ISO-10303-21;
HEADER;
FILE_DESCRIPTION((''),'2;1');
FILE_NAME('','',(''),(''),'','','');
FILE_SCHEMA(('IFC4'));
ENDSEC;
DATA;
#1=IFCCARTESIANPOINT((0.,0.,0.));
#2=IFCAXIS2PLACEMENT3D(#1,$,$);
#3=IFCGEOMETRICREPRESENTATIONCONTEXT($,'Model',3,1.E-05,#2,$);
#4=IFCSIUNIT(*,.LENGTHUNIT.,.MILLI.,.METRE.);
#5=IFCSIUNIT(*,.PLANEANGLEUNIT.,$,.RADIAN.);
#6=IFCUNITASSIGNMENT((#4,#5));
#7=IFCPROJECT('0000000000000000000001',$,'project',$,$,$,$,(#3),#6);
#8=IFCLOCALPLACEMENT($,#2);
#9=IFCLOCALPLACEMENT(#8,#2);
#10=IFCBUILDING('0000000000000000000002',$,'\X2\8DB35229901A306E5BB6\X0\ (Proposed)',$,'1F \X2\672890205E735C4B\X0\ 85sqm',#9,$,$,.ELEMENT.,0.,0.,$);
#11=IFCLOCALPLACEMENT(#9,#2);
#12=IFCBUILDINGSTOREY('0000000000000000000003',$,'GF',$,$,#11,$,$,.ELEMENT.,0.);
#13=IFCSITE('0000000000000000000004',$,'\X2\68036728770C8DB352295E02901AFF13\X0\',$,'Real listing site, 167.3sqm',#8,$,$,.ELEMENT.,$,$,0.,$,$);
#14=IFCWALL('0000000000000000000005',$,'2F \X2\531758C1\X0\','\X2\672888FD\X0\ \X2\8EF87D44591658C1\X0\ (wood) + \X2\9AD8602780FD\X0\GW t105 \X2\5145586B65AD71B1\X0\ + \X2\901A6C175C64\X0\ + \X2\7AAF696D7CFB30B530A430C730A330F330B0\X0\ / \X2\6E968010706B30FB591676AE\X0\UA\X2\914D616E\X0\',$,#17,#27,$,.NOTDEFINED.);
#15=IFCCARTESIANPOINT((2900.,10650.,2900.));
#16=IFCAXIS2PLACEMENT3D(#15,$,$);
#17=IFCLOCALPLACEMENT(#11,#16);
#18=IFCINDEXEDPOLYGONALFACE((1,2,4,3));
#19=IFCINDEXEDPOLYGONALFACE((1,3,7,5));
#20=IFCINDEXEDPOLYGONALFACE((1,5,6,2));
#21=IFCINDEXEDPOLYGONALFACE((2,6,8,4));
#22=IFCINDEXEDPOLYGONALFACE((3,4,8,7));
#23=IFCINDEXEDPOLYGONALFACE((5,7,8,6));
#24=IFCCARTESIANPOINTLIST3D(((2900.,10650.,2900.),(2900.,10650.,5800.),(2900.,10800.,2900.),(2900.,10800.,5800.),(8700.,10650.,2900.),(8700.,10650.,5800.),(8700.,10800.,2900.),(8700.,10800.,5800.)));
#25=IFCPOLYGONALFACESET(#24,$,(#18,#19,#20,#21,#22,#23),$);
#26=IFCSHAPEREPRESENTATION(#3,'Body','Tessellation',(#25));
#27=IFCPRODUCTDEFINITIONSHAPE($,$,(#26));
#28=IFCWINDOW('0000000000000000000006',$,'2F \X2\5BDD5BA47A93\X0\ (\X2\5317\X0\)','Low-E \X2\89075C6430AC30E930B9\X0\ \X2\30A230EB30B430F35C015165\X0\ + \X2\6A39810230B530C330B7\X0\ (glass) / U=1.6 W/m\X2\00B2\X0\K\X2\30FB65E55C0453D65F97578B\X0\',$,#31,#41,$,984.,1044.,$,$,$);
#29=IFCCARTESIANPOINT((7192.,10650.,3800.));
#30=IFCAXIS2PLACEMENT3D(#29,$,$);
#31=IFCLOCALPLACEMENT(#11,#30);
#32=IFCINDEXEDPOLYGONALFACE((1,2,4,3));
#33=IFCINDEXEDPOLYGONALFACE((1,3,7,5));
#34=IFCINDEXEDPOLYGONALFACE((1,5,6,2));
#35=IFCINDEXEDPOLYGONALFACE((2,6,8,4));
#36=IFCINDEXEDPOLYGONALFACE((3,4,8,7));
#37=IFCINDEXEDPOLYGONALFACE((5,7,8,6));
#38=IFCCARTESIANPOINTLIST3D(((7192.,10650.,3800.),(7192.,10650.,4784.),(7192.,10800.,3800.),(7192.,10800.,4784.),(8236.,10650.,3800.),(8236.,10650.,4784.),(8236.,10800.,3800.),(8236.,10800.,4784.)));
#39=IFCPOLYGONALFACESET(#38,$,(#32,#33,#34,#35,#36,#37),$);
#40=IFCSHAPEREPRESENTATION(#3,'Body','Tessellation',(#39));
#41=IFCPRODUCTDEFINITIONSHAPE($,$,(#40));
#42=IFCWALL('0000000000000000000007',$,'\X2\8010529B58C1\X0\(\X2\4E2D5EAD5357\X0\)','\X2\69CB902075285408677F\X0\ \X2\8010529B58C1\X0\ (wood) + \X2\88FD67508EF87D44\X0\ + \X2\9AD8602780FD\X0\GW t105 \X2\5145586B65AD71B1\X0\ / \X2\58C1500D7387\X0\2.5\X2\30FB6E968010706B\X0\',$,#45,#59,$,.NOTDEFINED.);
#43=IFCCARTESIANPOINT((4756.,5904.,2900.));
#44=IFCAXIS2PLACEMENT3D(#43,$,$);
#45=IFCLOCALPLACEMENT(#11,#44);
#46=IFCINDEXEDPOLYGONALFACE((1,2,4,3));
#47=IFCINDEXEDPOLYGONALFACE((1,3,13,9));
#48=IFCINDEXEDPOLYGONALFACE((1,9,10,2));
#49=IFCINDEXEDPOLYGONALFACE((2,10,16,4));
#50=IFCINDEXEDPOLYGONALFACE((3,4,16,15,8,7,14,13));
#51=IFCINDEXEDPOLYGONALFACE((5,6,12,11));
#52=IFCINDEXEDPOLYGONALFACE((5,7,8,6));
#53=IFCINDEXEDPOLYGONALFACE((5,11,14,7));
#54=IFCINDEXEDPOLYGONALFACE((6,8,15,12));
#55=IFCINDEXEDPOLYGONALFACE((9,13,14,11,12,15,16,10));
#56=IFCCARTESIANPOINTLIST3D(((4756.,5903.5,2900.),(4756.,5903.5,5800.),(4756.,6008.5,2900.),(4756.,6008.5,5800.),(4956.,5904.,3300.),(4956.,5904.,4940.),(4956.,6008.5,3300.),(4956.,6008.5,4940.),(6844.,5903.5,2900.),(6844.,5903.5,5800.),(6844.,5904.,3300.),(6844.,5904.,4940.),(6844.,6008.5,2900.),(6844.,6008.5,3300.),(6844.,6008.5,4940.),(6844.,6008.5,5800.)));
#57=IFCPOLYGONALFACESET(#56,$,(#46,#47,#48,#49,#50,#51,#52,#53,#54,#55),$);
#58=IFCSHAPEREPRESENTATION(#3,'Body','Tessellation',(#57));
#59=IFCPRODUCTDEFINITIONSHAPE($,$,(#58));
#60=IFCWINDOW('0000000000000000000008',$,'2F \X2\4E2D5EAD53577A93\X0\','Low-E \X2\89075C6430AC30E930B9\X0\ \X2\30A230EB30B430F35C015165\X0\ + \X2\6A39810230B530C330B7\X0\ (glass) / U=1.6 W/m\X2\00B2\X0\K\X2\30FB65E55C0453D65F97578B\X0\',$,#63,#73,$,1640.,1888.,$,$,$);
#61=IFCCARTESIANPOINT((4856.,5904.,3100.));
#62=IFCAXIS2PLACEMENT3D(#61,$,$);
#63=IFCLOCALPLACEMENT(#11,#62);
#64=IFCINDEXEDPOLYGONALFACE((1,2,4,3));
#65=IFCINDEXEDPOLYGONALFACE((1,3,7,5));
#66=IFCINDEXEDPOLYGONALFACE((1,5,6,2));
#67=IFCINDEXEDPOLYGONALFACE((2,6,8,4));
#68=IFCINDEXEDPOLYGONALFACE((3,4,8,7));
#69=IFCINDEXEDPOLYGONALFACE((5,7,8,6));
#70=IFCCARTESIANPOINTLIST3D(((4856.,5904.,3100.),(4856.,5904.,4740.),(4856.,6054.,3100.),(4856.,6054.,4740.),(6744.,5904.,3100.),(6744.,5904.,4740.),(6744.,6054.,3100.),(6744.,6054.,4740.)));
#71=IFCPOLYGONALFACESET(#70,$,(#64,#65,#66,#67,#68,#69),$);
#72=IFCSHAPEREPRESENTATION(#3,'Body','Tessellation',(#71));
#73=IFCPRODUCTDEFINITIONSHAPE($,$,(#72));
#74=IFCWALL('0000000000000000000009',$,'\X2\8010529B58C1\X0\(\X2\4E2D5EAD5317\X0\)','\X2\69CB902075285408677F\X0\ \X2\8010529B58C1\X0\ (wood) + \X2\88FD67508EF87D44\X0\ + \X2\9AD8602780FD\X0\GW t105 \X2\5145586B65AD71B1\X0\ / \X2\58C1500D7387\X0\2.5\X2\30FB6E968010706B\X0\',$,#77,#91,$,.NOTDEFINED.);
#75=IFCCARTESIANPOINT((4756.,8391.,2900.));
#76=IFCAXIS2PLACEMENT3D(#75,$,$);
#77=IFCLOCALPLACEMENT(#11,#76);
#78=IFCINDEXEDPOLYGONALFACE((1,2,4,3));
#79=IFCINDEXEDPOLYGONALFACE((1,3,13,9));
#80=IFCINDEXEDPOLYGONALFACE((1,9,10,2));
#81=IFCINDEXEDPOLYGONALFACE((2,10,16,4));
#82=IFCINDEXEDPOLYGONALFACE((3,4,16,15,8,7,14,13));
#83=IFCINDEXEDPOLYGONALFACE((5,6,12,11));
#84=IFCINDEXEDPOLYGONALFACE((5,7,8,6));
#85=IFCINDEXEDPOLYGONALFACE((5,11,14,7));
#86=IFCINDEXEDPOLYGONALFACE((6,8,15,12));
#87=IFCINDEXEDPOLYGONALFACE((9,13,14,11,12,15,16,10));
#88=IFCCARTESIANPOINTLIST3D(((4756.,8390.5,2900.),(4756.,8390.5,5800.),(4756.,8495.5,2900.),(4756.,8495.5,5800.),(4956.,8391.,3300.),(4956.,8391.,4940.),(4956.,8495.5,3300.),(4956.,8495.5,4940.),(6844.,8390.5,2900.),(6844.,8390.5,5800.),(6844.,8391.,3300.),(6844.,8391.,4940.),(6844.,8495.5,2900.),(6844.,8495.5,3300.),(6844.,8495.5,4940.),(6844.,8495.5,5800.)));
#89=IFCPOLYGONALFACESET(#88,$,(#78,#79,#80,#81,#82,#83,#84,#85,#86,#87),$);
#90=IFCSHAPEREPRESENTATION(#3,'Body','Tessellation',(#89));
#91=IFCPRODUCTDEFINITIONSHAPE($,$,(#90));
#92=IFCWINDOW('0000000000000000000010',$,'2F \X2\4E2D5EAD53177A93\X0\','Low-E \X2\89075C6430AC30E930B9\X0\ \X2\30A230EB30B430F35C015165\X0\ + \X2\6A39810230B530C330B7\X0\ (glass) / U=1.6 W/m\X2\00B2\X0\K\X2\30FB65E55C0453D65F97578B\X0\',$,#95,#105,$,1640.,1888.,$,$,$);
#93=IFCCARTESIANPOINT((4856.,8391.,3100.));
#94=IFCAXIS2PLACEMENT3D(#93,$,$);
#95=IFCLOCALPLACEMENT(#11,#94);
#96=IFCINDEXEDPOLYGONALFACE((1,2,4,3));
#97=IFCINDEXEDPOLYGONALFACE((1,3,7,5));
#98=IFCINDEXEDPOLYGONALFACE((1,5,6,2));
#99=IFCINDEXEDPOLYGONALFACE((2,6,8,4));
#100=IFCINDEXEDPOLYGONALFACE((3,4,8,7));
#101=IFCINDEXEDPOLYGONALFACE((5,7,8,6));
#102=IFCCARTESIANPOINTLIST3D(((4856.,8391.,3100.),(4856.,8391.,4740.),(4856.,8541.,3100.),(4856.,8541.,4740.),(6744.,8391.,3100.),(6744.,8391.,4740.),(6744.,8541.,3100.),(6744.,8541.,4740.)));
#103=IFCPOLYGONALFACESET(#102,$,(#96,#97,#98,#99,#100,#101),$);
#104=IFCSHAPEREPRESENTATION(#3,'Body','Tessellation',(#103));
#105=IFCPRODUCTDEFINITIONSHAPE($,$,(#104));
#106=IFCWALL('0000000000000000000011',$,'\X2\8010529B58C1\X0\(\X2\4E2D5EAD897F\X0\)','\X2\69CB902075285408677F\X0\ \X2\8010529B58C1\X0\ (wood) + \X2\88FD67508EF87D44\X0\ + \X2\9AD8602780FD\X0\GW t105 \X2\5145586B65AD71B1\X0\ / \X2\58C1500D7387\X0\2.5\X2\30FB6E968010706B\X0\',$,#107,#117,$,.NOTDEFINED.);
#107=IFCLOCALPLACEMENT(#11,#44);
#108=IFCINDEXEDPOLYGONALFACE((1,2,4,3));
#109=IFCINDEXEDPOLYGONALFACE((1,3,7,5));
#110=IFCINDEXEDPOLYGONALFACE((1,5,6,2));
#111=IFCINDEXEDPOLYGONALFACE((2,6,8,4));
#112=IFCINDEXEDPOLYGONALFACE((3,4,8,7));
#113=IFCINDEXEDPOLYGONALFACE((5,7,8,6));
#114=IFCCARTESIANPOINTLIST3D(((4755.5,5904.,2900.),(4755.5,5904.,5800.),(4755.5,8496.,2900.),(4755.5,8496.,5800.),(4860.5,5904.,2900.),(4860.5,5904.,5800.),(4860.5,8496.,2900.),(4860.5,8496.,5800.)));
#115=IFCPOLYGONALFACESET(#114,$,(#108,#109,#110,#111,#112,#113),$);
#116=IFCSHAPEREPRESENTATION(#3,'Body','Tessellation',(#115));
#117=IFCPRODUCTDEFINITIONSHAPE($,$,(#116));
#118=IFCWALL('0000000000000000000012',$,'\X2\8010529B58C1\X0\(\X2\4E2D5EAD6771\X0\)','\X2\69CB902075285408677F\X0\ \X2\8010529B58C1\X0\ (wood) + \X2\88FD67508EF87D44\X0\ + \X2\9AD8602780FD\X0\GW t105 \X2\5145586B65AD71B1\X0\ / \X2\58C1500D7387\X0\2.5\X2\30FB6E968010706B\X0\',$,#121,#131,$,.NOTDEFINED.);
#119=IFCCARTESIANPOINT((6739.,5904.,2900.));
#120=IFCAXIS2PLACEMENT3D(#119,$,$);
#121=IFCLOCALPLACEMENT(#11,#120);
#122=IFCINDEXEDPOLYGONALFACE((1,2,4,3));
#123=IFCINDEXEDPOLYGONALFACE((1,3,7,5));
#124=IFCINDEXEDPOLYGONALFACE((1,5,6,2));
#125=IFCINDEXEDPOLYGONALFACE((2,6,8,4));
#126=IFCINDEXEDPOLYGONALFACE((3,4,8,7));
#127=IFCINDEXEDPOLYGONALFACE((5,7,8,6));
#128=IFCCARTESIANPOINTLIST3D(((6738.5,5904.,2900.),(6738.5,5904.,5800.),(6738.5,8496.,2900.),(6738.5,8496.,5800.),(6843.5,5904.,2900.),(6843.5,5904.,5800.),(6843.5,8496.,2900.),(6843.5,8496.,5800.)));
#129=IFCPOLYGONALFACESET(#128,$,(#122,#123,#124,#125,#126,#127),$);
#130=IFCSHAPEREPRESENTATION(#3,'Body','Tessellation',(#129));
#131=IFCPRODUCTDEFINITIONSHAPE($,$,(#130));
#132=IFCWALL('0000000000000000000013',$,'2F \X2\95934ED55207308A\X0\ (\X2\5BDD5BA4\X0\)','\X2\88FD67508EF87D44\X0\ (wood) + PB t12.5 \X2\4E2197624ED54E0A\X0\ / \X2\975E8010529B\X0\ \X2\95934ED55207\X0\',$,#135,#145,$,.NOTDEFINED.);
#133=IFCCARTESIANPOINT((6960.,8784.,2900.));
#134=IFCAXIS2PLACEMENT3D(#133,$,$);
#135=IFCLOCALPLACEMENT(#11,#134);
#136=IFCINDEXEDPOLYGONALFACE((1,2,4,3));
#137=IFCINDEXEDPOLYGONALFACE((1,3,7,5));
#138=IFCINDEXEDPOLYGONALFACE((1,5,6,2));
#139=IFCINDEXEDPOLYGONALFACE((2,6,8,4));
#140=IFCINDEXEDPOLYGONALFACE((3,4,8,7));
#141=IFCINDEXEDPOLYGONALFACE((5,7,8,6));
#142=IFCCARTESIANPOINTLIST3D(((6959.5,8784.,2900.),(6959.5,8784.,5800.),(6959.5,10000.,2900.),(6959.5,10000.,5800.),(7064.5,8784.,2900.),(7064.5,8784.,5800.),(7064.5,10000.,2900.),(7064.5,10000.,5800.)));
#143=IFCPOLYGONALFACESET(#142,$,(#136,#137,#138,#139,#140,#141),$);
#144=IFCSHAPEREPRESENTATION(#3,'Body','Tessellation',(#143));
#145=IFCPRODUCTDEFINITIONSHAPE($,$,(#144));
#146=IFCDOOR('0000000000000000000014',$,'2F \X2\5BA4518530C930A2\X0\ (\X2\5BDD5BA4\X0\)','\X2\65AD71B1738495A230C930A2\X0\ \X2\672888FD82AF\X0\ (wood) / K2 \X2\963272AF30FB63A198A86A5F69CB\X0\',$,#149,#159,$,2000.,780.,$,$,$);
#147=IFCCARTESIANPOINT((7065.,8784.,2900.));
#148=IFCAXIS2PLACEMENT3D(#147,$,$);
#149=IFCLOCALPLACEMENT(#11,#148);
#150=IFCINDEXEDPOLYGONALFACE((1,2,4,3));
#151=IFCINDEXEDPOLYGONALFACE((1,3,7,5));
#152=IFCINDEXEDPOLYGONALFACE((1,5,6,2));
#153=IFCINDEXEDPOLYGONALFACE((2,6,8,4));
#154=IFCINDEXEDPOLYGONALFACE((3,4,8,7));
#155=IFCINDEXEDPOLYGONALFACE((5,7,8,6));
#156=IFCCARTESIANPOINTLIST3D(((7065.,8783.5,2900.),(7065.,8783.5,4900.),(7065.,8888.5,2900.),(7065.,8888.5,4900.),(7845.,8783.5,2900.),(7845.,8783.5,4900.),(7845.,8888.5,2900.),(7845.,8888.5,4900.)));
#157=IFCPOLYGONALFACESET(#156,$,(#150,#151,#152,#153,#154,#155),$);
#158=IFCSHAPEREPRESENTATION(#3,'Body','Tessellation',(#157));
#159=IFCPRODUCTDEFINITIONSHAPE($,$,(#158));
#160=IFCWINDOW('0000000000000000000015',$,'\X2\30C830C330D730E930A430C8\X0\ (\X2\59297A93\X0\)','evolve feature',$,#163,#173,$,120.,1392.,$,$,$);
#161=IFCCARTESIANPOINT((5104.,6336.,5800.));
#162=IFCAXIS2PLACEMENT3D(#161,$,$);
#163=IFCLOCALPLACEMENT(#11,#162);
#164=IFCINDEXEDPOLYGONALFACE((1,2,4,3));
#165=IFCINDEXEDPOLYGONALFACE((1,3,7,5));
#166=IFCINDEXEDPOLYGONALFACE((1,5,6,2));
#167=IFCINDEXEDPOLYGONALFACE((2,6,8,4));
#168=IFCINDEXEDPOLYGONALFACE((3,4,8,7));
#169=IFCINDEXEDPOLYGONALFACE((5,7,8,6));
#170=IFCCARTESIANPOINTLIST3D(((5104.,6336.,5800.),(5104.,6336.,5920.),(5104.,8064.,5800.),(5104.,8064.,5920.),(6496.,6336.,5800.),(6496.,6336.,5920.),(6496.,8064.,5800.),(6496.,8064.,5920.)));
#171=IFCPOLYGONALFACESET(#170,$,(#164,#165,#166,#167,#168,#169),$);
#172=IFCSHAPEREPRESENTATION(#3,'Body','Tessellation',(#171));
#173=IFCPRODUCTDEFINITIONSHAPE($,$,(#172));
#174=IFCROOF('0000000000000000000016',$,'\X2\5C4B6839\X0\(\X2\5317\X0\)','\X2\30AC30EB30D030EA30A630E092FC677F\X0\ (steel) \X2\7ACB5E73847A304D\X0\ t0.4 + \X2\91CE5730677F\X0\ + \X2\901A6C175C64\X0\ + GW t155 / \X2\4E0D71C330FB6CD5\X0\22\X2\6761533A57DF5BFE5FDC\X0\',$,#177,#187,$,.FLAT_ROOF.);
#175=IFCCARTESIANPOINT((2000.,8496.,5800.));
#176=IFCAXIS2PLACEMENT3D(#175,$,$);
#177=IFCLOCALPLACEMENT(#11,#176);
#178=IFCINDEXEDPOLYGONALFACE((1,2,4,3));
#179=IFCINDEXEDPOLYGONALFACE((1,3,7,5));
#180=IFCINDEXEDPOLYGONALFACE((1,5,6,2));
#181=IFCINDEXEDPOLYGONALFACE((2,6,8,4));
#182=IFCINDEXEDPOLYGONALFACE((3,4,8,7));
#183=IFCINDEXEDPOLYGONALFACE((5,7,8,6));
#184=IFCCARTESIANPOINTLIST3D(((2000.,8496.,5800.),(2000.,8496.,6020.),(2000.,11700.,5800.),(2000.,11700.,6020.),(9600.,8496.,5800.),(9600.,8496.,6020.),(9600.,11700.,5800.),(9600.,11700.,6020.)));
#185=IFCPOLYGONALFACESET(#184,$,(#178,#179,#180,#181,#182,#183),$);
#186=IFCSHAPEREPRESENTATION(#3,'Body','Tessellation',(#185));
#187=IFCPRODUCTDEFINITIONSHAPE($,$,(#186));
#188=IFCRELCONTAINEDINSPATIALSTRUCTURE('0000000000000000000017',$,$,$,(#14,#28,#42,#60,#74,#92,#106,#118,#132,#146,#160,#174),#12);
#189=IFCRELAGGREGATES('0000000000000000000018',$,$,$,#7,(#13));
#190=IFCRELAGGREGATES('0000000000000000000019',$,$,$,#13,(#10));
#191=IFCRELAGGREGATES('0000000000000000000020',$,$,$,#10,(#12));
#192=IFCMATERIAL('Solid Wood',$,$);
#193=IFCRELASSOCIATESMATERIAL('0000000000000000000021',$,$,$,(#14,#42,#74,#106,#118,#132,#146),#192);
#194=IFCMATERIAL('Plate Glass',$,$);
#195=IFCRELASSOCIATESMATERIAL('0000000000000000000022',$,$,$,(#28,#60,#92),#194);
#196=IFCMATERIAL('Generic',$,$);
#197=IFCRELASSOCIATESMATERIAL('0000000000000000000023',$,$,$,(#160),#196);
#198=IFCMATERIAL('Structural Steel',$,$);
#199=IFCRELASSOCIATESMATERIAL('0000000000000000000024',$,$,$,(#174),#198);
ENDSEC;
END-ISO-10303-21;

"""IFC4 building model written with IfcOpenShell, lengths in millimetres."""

from ifc_helpers import new_model, si_unit, frame, frame_2d, origin, place, context, project, spatial, rectangle, extrude, material, element, fill, save


model = new_model("IFC4")

# Units and contexts
model_context = context("Model", 3, precision=1e-05, world=origin())
ifc_project = project(units=[si_unit("LENGTHUNIT", "METRE", prefix="MILLI"), si_unit("PLANEANGLEUNIT", "RADIAN")], contexts=[model_context])

# Site, building, storey
site_placement = place(None, origin())
site = spatial("IfcSite", under=ifc_project, at=site_placement, Name="栃木県足利市通３", ObjectType="Real listing site, 167.3sqm", CompositionType="ELEMENT", RefElevation=0.0)
building_placement = place(site_placement, origin())
building = spatial("IfcBuilding", under=site, at=building_placement, Name="足利通の家 (Proposed)", ObjectType="1F 木造平屋 85sqm", CompositionType="ELEMENT", ElevationOfRefHeight=0.0, ElevationOfTerrain=0.0)
storey_placement = place(building_placement, origin())
storey = spatial("IfcBuildingStorey", under=building, at=storey_placement, Name="GF", CompositionType="ELEMENT", Elevation=0.0)

# Shared definitions
ifc_material_1 = material(Name="Solid Wood")

# Walls, openings, windows
wall_1_placement = place(storey_placement, frame((2900.0, 10650.0, 2900.0)))
wall_1 = element("IfcWall", 1, at=wall_1_placement, inside=storey, material=ifc_material_1, Name="2F 北壁", Description="木製 軸組外壁 (wood) + 高性能GW t105 充填断熱 + 通気層 + 窯業系サイディング / 準耐火・外皮UA配慮", PredefinedType="NOTDEFINED", context=model_context, shape_type="SweptSolid", body=[
    extrude(rectangle(XDim=5800.0, YDim=150.0, at=frame_2d((2900.0, 75.0))), frame((2900.0, 10650.0, 2900.0)), (0.0, 0.0, 1.0), 2900.0),
])
opening_1_placement = place(storey_placement, frame((7192.0, 10650.0, 3800.0)))
opening_1 = element("IfcOpeningElement", 2, at=opening_1_placement, cuts=wall_1, PredefinedType="NOTDEFINED", context=model_context, shape_type="SweptSolid", body=[
    extrude(rectangle(XDim=1044.0, YDim=150.0, at=frame_2d((522.0, 75.0))), frame((7192.0, 10650.0, 3800.0)), (0.0, 0.0, 1.0), 984.0),
])
ifc_material_2 = material(Name="Plate Glass")
window_1_placement = place(storey_placement, frame((7192.0, 10650.0, 3800.0)))
window_1 = element("IfcWindow", 3, at=window_1_placement, inside=storey, material=ifc_material_2, Name="2F 寝室窓 (北)", Description="Low-E 複層ガラス アルゴン封入 + 樹脂サッシ (glass) / U=1.6 W/m²K・日射取得型", OverallHeight=984.0, OverallWidth=1044.0, context=model_context, shape_type="SweptSolid", body=[
    extrude(rectangle(XDim=1044.0, YDim=150.0, at=frame_2d((522.0, 75.0))), frame((7192.0, 10650.0, 3800.0)), (0.0, 0.0, 1.0), 984.0),
])
fill(opening_1, window_1)
wall_2_placement = place(storey_placement, frame((4756.0, 5904.0, 2900.0)))
wall_2 = element("IfcWall", 4, at=wall_2_placement, inside=storey, material=ifc_material_1, Name="耐力壁(中庭南)", Description="構造用合板 耐力壁 (wood) + 製材軸組 + 高性能GW t105 充填断熱 / 壁倍率2.5・準耐火", PredefinedType="NOTDEFINED", context=model_context, shape_type="SweptSolid", body=[
    extrude(rectangle(XDim=2088.0, YDim=105.0, at=frame_2d((1044.0, 52.0))), frame((4756.0, 5904.0, 2900.0)), (0.0, 0.0, 1.0), 2900.0),
])
opening_2_placement = place(storey_placement, frame((4856.0, 5904.0, 3100.0)))
opening_2 = element("IfcOpeningElement", 5, at=opening_2_placement, cuts=wall_2, PredefinedType="NOTDEFINED", context=model_context, shape_type="SweptSolid", body=[
    extrude(rectangle(XDim=1888.0, YDim=150.0, at=frame_2d((944.0, 75.0))), frame((4856.0, 5904.0, 3100.0)), (0.0, 0.0, 1.0), 1640.0),
])
window_2_placement = place(storey_placement, frame((4856.0, 5904.0, 3100.0)))
window_2 = element("IfcWindow", 6, at=window_2_placement, inside=storey, material=ifc_material_2, Name="2F 中庭南窓", Description="Low-E 複層ガラス アルゴン封入 + 樹脂サッシ (glass) / U=1.6 W/m²K・日射取得型", OverallHeight=1640.0, OverallWidth=1888.0, context=model_context, shape_type="SweptSolid", body=[
    extrude(rectangle(XDim=1888.0, YDim=150.0, at=frame_2d((944.0, 75.0))), frame((4856.0, 5904.0, 3100.0)), (0.0, 0.0, 1.0), 1640.0),
])
fill(opening_2, window_2)
wall_3_placement = place(storey_placement, frame((4756.0, 8391.0, 2900.0)))
wall_3 = element("IfcWall", 7, at=wall_3_placement, inside=storey, material=ifc_material_1, Name="耐力壁(中庭北)", Description="構造用合板 耐力壁 (wood) + 製材軸組 + 高性能GW t105 充填断熱 / 壁倍率2.5・準耐火", PredefinedType="NOTDEFINED", context=model_context, shape_type="SweptSolid", body=[
    extrude(rectangle(XDim=2088.0, YDim=105.0, at=frame_2d((1044.0, 52.0))), frame((4756.0, 8391.0, 2900.0)), (0.0, 0.0, 1.0), 2900.0),
])
opening_3_placement = place(storey_placement, frame((4856.0, 8391.0, 3100.0)))
opening_3 = element("IfcOpeningElement", 8, at=opening_3_placement, cuts=wall_3, PredefinedType="NOTDEFINED", context=model_context, shape_type="SweptSolid", body=[
    extrude(rectangle(XDim=1888.0, YDim=150.0, at=frame_2d((944.0, 75.0))), frame((4856.0, 8391.0, 3100.0)), (0.0, 0.0, 1.0), 1640.0),
])
window_3_placement = place(storey_placement, frame((4856.0, 8391.0, 3100.0)))
window_3 = element("IfcWindow", 9, at=window_3_placement, inside=storey, material=ifc_material_2, Name="2F 中庭北窓", Description="Low-E 複層ガラス アルゴン封入 + 樹脂サッシ (glass) / U=1.6 W/m²K・日射取得型", OverallHeight=1640.0, OverallWidth=1888.0, context=model_context, shape_type="SweptSolid", body=[
    extrude(rectangle(XDim=1888.0, YDim=150.0, at=frame_2d((944.0, 75.0))), frame((4856.0, 8391.0, 3100.0)), (0.0, 0.0, 1.0), 1640.0),
])
fill(opening_3, window_3)

# Walls
wall_4_placement = place(storey_placement, frame((4756.0, 5904.0, 2900.0)))
element("IfcWall", 10, at=wall_4_placement, inside=storey, material=ifc_material_1, Name="耐力壁(中庭西)", Description="構造用合板 耐力壁 (wood) + 製材軸組 + 高性能GW t105 充填断熱 / 壁倍率2.5・準耐火", PredefinedType="NOTDEFINED", context=model_context, shape_type="SweptSolid", body=[
    extrude(rectangle(XDim=105.0, YDim=2592.0, at=frame_2d((52.0, 1296.0))), frame((4756.0, 5904.0, 2900.0)), (0.0, 0.0, 1.0), 2900.0),
])
wall_5_placement = place(storey_placement, frame((6739.0, 5904.0, 2900.0)))
element("IfcWall", 11, at=wall_5_placement, inside=storey, material=ifc_material_1, Name="耐力壁(中庭東)", Description="構造用合板 耐力壁 (wood) + 製材軸組 + 高性能GW t105 充填断熱 / 壁倍率2.5・準耐火", PredefinedType="NOTDEFINED", context=model_context, shape_type="SweptSolid", body=[
    extrude(rectangle(XDim=105.0, YDim=2592.0, at=frame_2d((52.0, 1296.0))), frame((6739.0, 5904.0, 2900.0)), (0.0, 0.0, 1.0), 2900.0),
])
wall_6_placement = place(storey_placement, frame((6960.0, 8784.0, 2900.0)))
element("IfcWall", 12, at=wall_6_placement, inside=storey, material=ifc_material_1, Name="2F 間仕切り (寝室)", Description="製材軸組 (wood) + PB t12.5 両面仕上 / 非耐力 間仕切", PredefinedType="NOTDEFINED", context=model_context, shape_type="SweptSolid", body=[
    extrude(rectangle(XDim=105.0, YDim=1216.0, at=frame_2d((52.0, 608.0))), frame((6960.0, 8784.0, 2900.0)), (0.0, 0.0, 1.0), 2900.0),
])

# Door
door_placement = place(storey_placement, frame((7065.0, 8784.0, 2900.0)))
element("IfcDoor", 13, at=door_placement, inside=storey, material=ifc_material_1, Name="2F 室内ドア (寝室)", Description="断熱玄関ドア 木製芯 (wood) / K2 防犯・採風機構", OverallHeight=2000.0, OverallWidth=780.0, context=model_context, shape_type="SweptSolid", body=[
    extrude(rectangle(XDim=780.0, YDim=105.0, at=frame_2d((390.0, 52.0))), frame((7065.0, 8784.0, 2900.0)), (0.0, 0.0, 1.0), 2000.0),
])

# Window
ifc_material_3 = material(Name="Generic")
window_4_placement = place(storey_placement, frame((5104.0, 6336.0, 5800.0)))
element("IfcWindow", 14, at=window_4_placement, inside=storey, material=ifc_material_3, Name="トップライト (天窓)", Description="evolve feature", OverallHeight=120.0, OverallWidth=1392.0, context=model_context, shape_type="SweptSolid", body=[
    extrude(rectangle(XDim=1392.0, YDim=1728.0, at=frame_2d((696.0, 864.0))), frame((5104.0, 6336.0, 5800.0)), (0.0, 0.0, 1.0), 120.0),
])

# Roof
ifc_material_4 = material(Name="Structural Steel")
for number, where, name in (
    (15, (2000.0, 8496.0, 5800.0), "屋根(北)"),
):
    element("IfcRoof", number, at=place(storey_placement, frame(where)), inside=storey, material=ifc_material_4, Name=name, Description="ガルバリウム鋼板 (steel) 立平葺き t0.4 + 野地板 + 通気層 + GW t155 / 不燃・法22条区域対応", PredefinedType="FLAT_ROOF", context=model_context, shape_type="SweptSolid", body=[
        extrude(rectangle(XDim=7600.0, YDim=3204.0, at=frame_2d((3800.0, 1602.0))), frame((2000.0, 8496.0, 5800.0)), (0.0, 0.0, 1.0), 220.0),
    ])

save(model, "model.ifc")
